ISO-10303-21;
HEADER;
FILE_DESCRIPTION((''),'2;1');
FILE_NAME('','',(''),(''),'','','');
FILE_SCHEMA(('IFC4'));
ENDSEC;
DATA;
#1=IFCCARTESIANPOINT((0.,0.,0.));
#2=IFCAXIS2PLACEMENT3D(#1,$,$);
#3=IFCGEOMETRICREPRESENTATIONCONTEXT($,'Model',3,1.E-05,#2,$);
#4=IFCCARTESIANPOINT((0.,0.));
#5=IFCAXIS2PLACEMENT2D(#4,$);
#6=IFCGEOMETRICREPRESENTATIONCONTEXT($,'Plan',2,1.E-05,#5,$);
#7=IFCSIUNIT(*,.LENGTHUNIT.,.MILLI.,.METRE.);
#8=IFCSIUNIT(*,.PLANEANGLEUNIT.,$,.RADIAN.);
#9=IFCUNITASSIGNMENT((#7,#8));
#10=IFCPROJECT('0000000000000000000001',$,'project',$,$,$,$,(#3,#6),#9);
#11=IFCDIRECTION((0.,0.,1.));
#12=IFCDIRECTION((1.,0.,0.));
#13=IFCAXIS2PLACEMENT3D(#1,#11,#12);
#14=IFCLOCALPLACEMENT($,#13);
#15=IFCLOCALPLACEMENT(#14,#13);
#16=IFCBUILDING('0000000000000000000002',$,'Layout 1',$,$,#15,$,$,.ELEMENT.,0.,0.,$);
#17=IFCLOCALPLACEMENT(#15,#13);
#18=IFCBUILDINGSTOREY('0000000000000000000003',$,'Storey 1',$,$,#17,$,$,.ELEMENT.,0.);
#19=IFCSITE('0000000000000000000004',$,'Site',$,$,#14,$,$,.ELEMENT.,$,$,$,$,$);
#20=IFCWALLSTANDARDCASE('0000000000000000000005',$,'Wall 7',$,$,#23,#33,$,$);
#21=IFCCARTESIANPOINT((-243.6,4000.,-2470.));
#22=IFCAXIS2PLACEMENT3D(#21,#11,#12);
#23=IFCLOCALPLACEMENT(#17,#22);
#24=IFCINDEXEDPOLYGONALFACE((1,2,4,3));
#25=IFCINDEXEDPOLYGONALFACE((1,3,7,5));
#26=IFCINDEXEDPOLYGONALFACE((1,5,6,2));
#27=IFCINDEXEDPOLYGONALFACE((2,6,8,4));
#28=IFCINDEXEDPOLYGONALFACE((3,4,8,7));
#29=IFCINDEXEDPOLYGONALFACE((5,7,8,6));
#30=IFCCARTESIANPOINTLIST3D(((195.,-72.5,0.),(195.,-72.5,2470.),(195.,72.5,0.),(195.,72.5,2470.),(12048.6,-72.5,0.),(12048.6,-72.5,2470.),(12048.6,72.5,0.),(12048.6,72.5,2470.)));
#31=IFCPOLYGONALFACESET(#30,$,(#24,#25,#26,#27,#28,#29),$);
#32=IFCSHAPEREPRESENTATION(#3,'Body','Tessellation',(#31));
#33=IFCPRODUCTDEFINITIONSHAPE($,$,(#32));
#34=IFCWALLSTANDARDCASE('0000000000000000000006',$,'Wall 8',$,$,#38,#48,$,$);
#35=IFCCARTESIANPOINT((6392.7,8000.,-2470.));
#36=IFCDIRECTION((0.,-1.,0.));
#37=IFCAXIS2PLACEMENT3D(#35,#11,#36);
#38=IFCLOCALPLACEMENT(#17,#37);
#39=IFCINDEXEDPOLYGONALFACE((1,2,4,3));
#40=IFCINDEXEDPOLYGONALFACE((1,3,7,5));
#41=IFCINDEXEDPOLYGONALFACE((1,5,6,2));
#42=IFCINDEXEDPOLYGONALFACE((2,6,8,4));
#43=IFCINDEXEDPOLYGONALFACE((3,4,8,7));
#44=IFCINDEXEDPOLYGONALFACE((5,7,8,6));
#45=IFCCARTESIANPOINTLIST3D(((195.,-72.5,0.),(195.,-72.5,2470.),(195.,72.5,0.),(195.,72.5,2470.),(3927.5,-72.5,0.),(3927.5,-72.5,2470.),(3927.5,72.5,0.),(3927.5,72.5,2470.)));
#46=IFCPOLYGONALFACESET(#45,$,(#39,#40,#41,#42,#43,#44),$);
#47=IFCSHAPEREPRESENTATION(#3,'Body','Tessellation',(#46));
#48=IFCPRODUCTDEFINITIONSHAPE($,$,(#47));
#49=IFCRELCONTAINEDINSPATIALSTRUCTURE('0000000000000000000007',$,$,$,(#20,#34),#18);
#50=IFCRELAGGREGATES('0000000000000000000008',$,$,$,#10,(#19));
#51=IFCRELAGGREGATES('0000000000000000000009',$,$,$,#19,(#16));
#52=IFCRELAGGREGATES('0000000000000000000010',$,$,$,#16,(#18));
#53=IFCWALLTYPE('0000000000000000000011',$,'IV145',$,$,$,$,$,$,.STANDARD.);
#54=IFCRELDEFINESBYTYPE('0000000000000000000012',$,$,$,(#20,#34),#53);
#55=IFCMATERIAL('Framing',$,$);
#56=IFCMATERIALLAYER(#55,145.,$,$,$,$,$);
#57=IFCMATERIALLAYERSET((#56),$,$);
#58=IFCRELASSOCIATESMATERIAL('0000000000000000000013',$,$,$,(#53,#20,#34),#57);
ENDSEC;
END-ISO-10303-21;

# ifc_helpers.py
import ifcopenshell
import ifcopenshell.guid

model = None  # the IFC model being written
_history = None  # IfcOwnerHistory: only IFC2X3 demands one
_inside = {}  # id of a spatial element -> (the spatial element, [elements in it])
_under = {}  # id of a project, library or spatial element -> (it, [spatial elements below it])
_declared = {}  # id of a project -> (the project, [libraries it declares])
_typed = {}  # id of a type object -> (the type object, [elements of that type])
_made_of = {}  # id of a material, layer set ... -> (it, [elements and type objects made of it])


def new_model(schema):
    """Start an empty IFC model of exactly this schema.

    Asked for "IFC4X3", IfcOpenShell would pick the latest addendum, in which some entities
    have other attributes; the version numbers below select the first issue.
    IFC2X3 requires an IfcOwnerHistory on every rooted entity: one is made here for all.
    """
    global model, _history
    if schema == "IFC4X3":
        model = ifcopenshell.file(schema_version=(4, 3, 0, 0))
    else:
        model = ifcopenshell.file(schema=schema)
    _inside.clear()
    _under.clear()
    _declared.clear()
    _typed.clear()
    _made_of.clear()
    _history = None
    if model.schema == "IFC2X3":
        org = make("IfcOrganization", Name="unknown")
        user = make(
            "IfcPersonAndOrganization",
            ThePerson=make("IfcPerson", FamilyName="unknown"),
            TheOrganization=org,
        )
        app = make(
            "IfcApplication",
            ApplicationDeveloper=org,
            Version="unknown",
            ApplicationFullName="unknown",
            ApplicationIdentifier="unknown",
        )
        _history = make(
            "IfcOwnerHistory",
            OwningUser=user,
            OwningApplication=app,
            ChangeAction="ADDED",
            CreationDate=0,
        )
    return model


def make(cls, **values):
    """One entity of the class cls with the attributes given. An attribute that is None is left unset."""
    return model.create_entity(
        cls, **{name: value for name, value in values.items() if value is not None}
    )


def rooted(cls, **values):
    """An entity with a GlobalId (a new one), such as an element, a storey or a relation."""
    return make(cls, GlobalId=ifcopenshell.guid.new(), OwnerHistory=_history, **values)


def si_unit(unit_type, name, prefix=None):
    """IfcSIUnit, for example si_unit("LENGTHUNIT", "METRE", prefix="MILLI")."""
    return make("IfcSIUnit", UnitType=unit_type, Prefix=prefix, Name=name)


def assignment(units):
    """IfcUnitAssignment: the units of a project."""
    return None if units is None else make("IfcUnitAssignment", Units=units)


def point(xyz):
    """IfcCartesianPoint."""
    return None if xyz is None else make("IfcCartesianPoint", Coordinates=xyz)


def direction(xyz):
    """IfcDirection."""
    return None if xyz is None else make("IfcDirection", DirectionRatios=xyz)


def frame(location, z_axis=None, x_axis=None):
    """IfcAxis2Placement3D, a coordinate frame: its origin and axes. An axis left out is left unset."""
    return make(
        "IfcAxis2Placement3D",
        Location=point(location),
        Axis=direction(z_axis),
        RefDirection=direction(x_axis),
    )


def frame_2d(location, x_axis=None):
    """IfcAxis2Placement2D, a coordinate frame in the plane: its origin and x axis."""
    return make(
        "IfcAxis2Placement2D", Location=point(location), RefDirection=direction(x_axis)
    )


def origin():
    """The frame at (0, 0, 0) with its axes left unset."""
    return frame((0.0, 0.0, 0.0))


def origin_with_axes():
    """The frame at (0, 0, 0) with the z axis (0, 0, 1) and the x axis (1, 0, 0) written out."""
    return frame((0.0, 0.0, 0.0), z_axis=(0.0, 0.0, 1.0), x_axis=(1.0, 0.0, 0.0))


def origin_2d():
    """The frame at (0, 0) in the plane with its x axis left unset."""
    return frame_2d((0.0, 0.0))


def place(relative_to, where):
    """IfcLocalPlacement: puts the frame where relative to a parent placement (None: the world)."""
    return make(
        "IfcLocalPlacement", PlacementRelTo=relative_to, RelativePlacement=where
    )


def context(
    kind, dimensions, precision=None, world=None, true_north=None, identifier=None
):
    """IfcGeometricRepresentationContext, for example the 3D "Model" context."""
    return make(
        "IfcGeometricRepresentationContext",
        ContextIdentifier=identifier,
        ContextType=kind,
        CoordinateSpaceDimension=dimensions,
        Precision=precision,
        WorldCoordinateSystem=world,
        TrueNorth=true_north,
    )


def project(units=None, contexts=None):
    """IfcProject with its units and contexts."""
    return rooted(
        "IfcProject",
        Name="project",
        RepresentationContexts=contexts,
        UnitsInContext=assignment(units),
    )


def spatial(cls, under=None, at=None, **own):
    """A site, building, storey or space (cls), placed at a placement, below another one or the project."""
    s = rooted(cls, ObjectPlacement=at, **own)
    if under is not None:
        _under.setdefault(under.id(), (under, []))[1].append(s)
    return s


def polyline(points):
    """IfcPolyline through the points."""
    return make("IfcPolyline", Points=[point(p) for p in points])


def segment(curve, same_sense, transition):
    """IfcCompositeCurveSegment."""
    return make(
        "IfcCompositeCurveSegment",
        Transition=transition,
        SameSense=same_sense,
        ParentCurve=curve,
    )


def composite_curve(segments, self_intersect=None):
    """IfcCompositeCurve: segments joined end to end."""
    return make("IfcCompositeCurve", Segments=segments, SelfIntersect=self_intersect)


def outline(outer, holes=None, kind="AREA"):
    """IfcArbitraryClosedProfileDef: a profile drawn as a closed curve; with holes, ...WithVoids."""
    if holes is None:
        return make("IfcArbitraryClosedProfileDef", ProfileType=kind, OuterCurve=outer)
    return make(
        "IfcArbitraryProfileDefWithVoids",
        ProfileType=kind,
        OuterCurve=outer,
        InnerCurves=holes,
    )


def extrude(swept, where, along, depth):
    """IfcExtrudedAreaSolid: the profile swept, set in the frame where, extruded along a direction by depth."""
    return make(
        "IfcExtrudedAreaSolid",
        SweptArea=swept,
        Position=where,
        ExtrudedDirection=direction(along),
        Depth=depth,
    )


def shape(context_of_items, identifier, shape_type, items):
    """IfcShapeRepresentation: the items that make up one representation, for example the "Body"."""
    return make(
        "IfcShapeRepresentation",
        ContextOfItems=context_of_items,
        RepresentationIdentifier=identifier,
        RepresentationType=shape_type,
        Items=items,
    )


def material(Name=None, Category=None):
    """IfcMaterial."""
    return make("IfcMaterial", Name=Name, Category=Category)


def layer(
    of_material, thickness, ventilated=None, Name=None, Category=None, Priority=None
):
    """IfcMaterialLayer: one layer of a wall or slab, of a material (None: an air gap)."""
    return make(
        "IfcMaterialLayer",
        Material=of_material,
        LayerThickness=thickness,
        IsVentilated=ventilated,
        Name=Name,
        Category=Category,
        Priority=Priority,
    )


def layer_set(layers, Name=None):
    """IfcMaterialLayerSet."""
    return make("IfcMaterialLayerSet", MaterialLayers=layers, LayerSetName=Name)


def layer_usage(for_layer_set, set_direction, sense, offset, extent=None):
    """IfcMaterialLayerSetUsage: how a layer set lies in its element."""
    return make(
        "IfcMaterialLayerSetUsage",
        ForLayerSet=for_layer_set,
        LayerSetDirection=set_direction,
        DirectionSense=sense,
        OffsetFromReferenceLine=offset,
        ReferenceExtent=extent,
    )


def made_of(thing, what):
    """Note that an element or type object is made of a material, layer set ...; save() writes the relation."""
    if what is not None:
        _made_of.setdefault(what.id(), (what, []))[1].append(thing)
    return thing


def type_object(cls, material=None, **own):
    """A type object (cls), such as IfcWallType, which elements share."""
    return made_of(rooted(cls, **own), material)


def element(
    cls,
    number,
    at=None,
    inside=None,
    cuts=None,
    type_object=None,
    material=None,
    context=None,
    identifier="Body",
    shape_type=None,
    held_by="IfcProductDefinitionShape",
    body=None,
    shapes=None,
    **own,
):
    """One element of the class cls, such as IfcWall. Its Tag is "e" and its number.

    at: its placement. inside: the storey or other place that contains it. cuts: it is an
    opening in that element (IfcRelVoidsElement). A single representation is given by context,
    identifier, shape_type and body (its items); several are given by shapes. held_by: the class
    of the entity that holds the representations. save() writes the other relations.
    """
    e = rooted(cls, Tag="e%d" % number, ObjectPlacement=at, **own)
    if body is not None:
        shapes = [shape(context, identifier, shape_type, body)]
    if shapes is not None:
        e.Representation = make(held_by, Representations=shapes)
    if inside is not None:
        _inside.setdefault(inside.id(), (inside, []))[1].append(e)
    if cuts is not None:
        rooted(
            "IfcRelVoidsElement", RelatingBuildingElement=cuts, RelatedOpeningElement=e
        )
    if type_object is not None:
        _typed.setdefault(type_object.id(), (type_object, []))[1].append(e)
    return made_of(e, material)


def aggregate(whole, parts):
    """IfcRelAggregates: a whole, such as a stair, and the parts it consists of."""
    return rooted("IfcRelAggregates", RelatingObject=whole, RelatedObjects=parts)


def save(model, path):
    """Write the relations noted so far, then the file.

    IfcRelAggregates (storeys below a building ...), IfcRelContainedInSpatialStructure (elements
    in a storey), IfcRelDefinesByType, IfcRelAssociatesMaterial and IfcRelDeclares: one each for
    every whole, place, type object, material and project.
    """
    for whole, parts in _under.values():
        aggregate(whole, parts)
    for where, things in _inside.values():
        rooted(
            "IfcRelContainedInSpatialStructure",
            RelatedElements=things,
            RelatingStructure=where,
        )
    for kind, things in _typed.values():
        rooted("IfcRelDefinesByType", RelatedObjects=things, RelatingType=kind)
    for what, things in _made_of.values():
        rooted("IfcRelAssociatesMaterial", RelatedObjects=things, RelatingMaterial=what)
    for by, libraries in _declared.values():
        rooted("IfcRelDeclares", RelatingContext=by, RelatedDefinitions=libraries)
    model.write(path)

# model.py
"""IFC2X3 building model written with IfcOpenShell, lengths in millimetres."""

from ifc_helpers import new_model, si_unit, frame, origin, origin_with_axes, origin_2d, place, context, project, spatial, polyline, segment, composite_curve, outline, extrude, material, layer, layer_set, layer_usage, type_object, element, save


model = new_model("IFC2X3")

# Units and contexts
model_context = context("Model", 3, precision=1e-05, world=origin())
plan_context = context("Plan", 2, precision=1e-05, world=origin_2d())
ifc_project = project(units=[si_unit("LENGTHUNIT", "METRE", prefix="MILLI"), si_unit("PLANEANGLEUNIT", "RADIAN")], contexts=[model_context, plan_context])

# Site, building, storey
site_placement = place(None, origin_with_axes())
site = spatial("IfcSite", under=ifc_project, at=site_placement, Name="Site", CompositionType="ELEMENT")
building_placement = place(site_placement, origin_with_axes())
building = spatial("IfcBuilding", under=site, at=building_placement, Name="Layout 1", CompositionType="ELEMENT", ElevationOfRefHeight=0.0, ElevationOfTerrain=0.0)
storey_placement = place(building_placement, origin_with_axes())
storey = spatial("IfcBuildingStorey", under=building, at=storey_placement, Name="Storey 1", CompositionType="ELEMENT", Elevation=0.0)

# Walls
ifc_material_1 = material(Name="Framing")
ifc_layer_1 = layer(ifc_material_1, 145.0)
ifc_layer_set_1 = layer_set([ifc_layer_1])
ifc_layer_usage_1 = layer_usage(ifc_layer_set_1, "AXIS2", "POSITIVE", -72.5)
wall_type_1 = type_object("IfcWallType", Name="IV145", PredefinedType="STANDARD", material=ifc_layer_set_1)
wall_1_placement = place(storey_placement, frame((-243.6, 4000.0, -2470.0), z_axis=(0.0, 0.0, 1.0), x_axis=(1.0, 0.0, 0.0)))
element("IfcWallStandardCase", 1, at=wall_1_placement, inside=storey, type_object=wall_type_1, material=ifc_layer_usage_1, Name="Wall 7", context=model_context, shape_type="SweptSolid", body=[
    extrude(outline(composite_curve([segment(polyline([(195.0, 72.5), (195.0, -72.5)]), True, "CONTINUOUS"), segment(polyline([(195.0, -72.5), (12048.6, -72.5)]), True, "CONTINUOUS"), segment(polyline([(12048.6, -72.5), (12048.6, 72.5)]), True, "CONTINUOUS"), segment(polyline([(12048.6, 72.5), (195.0, 72.5)]), True, "CONTINUOUS")], self_intersect=False)), origin_with_axes(), (0.0, 0.0, 1.0), 2470.0),
])
ifc_layer_usage_2 = layer_usage(ifc_layer_set_1, "AXIS2", "POSITIVE", -72.5)
wall_2_placement = place(storey_placement, frame((6392.7, 8000.0, -2470.0), z_axis=(0.0, 0.0, 1.0), x_axis=(0.0, -1.0, 0.0)))
element("IfcWallStandardCase", 2, at=wall_2_placement, inside=storey, type_object=wall_type_1, material=ifc_layer_usage_2, Name="Wall 8", context=model_context, shape_type="SweptSolid", body=[
    extrude(outline(composite_curve([segment(polyline([(195.0, 72.5), (195.0, -72.5)]), True, "CONTINUOUS"), segment(polyline([(195.0, -72.5), (3927.5, -72.5)]), True, "CONTINUOUS"), segment(polyline([(3927.5, -72.5), (3927.5, 72.5)]), True, "CONTINUOUS"), segment(polyline([(3927.5, 72.5), (195.0, 72.5)]), True, "CONTINUOUS")], self_intersect=False)), origin_with_axes(), (0.0, 0.0, 1.0), 2470.0),
])

save(model, "model.ifc")
